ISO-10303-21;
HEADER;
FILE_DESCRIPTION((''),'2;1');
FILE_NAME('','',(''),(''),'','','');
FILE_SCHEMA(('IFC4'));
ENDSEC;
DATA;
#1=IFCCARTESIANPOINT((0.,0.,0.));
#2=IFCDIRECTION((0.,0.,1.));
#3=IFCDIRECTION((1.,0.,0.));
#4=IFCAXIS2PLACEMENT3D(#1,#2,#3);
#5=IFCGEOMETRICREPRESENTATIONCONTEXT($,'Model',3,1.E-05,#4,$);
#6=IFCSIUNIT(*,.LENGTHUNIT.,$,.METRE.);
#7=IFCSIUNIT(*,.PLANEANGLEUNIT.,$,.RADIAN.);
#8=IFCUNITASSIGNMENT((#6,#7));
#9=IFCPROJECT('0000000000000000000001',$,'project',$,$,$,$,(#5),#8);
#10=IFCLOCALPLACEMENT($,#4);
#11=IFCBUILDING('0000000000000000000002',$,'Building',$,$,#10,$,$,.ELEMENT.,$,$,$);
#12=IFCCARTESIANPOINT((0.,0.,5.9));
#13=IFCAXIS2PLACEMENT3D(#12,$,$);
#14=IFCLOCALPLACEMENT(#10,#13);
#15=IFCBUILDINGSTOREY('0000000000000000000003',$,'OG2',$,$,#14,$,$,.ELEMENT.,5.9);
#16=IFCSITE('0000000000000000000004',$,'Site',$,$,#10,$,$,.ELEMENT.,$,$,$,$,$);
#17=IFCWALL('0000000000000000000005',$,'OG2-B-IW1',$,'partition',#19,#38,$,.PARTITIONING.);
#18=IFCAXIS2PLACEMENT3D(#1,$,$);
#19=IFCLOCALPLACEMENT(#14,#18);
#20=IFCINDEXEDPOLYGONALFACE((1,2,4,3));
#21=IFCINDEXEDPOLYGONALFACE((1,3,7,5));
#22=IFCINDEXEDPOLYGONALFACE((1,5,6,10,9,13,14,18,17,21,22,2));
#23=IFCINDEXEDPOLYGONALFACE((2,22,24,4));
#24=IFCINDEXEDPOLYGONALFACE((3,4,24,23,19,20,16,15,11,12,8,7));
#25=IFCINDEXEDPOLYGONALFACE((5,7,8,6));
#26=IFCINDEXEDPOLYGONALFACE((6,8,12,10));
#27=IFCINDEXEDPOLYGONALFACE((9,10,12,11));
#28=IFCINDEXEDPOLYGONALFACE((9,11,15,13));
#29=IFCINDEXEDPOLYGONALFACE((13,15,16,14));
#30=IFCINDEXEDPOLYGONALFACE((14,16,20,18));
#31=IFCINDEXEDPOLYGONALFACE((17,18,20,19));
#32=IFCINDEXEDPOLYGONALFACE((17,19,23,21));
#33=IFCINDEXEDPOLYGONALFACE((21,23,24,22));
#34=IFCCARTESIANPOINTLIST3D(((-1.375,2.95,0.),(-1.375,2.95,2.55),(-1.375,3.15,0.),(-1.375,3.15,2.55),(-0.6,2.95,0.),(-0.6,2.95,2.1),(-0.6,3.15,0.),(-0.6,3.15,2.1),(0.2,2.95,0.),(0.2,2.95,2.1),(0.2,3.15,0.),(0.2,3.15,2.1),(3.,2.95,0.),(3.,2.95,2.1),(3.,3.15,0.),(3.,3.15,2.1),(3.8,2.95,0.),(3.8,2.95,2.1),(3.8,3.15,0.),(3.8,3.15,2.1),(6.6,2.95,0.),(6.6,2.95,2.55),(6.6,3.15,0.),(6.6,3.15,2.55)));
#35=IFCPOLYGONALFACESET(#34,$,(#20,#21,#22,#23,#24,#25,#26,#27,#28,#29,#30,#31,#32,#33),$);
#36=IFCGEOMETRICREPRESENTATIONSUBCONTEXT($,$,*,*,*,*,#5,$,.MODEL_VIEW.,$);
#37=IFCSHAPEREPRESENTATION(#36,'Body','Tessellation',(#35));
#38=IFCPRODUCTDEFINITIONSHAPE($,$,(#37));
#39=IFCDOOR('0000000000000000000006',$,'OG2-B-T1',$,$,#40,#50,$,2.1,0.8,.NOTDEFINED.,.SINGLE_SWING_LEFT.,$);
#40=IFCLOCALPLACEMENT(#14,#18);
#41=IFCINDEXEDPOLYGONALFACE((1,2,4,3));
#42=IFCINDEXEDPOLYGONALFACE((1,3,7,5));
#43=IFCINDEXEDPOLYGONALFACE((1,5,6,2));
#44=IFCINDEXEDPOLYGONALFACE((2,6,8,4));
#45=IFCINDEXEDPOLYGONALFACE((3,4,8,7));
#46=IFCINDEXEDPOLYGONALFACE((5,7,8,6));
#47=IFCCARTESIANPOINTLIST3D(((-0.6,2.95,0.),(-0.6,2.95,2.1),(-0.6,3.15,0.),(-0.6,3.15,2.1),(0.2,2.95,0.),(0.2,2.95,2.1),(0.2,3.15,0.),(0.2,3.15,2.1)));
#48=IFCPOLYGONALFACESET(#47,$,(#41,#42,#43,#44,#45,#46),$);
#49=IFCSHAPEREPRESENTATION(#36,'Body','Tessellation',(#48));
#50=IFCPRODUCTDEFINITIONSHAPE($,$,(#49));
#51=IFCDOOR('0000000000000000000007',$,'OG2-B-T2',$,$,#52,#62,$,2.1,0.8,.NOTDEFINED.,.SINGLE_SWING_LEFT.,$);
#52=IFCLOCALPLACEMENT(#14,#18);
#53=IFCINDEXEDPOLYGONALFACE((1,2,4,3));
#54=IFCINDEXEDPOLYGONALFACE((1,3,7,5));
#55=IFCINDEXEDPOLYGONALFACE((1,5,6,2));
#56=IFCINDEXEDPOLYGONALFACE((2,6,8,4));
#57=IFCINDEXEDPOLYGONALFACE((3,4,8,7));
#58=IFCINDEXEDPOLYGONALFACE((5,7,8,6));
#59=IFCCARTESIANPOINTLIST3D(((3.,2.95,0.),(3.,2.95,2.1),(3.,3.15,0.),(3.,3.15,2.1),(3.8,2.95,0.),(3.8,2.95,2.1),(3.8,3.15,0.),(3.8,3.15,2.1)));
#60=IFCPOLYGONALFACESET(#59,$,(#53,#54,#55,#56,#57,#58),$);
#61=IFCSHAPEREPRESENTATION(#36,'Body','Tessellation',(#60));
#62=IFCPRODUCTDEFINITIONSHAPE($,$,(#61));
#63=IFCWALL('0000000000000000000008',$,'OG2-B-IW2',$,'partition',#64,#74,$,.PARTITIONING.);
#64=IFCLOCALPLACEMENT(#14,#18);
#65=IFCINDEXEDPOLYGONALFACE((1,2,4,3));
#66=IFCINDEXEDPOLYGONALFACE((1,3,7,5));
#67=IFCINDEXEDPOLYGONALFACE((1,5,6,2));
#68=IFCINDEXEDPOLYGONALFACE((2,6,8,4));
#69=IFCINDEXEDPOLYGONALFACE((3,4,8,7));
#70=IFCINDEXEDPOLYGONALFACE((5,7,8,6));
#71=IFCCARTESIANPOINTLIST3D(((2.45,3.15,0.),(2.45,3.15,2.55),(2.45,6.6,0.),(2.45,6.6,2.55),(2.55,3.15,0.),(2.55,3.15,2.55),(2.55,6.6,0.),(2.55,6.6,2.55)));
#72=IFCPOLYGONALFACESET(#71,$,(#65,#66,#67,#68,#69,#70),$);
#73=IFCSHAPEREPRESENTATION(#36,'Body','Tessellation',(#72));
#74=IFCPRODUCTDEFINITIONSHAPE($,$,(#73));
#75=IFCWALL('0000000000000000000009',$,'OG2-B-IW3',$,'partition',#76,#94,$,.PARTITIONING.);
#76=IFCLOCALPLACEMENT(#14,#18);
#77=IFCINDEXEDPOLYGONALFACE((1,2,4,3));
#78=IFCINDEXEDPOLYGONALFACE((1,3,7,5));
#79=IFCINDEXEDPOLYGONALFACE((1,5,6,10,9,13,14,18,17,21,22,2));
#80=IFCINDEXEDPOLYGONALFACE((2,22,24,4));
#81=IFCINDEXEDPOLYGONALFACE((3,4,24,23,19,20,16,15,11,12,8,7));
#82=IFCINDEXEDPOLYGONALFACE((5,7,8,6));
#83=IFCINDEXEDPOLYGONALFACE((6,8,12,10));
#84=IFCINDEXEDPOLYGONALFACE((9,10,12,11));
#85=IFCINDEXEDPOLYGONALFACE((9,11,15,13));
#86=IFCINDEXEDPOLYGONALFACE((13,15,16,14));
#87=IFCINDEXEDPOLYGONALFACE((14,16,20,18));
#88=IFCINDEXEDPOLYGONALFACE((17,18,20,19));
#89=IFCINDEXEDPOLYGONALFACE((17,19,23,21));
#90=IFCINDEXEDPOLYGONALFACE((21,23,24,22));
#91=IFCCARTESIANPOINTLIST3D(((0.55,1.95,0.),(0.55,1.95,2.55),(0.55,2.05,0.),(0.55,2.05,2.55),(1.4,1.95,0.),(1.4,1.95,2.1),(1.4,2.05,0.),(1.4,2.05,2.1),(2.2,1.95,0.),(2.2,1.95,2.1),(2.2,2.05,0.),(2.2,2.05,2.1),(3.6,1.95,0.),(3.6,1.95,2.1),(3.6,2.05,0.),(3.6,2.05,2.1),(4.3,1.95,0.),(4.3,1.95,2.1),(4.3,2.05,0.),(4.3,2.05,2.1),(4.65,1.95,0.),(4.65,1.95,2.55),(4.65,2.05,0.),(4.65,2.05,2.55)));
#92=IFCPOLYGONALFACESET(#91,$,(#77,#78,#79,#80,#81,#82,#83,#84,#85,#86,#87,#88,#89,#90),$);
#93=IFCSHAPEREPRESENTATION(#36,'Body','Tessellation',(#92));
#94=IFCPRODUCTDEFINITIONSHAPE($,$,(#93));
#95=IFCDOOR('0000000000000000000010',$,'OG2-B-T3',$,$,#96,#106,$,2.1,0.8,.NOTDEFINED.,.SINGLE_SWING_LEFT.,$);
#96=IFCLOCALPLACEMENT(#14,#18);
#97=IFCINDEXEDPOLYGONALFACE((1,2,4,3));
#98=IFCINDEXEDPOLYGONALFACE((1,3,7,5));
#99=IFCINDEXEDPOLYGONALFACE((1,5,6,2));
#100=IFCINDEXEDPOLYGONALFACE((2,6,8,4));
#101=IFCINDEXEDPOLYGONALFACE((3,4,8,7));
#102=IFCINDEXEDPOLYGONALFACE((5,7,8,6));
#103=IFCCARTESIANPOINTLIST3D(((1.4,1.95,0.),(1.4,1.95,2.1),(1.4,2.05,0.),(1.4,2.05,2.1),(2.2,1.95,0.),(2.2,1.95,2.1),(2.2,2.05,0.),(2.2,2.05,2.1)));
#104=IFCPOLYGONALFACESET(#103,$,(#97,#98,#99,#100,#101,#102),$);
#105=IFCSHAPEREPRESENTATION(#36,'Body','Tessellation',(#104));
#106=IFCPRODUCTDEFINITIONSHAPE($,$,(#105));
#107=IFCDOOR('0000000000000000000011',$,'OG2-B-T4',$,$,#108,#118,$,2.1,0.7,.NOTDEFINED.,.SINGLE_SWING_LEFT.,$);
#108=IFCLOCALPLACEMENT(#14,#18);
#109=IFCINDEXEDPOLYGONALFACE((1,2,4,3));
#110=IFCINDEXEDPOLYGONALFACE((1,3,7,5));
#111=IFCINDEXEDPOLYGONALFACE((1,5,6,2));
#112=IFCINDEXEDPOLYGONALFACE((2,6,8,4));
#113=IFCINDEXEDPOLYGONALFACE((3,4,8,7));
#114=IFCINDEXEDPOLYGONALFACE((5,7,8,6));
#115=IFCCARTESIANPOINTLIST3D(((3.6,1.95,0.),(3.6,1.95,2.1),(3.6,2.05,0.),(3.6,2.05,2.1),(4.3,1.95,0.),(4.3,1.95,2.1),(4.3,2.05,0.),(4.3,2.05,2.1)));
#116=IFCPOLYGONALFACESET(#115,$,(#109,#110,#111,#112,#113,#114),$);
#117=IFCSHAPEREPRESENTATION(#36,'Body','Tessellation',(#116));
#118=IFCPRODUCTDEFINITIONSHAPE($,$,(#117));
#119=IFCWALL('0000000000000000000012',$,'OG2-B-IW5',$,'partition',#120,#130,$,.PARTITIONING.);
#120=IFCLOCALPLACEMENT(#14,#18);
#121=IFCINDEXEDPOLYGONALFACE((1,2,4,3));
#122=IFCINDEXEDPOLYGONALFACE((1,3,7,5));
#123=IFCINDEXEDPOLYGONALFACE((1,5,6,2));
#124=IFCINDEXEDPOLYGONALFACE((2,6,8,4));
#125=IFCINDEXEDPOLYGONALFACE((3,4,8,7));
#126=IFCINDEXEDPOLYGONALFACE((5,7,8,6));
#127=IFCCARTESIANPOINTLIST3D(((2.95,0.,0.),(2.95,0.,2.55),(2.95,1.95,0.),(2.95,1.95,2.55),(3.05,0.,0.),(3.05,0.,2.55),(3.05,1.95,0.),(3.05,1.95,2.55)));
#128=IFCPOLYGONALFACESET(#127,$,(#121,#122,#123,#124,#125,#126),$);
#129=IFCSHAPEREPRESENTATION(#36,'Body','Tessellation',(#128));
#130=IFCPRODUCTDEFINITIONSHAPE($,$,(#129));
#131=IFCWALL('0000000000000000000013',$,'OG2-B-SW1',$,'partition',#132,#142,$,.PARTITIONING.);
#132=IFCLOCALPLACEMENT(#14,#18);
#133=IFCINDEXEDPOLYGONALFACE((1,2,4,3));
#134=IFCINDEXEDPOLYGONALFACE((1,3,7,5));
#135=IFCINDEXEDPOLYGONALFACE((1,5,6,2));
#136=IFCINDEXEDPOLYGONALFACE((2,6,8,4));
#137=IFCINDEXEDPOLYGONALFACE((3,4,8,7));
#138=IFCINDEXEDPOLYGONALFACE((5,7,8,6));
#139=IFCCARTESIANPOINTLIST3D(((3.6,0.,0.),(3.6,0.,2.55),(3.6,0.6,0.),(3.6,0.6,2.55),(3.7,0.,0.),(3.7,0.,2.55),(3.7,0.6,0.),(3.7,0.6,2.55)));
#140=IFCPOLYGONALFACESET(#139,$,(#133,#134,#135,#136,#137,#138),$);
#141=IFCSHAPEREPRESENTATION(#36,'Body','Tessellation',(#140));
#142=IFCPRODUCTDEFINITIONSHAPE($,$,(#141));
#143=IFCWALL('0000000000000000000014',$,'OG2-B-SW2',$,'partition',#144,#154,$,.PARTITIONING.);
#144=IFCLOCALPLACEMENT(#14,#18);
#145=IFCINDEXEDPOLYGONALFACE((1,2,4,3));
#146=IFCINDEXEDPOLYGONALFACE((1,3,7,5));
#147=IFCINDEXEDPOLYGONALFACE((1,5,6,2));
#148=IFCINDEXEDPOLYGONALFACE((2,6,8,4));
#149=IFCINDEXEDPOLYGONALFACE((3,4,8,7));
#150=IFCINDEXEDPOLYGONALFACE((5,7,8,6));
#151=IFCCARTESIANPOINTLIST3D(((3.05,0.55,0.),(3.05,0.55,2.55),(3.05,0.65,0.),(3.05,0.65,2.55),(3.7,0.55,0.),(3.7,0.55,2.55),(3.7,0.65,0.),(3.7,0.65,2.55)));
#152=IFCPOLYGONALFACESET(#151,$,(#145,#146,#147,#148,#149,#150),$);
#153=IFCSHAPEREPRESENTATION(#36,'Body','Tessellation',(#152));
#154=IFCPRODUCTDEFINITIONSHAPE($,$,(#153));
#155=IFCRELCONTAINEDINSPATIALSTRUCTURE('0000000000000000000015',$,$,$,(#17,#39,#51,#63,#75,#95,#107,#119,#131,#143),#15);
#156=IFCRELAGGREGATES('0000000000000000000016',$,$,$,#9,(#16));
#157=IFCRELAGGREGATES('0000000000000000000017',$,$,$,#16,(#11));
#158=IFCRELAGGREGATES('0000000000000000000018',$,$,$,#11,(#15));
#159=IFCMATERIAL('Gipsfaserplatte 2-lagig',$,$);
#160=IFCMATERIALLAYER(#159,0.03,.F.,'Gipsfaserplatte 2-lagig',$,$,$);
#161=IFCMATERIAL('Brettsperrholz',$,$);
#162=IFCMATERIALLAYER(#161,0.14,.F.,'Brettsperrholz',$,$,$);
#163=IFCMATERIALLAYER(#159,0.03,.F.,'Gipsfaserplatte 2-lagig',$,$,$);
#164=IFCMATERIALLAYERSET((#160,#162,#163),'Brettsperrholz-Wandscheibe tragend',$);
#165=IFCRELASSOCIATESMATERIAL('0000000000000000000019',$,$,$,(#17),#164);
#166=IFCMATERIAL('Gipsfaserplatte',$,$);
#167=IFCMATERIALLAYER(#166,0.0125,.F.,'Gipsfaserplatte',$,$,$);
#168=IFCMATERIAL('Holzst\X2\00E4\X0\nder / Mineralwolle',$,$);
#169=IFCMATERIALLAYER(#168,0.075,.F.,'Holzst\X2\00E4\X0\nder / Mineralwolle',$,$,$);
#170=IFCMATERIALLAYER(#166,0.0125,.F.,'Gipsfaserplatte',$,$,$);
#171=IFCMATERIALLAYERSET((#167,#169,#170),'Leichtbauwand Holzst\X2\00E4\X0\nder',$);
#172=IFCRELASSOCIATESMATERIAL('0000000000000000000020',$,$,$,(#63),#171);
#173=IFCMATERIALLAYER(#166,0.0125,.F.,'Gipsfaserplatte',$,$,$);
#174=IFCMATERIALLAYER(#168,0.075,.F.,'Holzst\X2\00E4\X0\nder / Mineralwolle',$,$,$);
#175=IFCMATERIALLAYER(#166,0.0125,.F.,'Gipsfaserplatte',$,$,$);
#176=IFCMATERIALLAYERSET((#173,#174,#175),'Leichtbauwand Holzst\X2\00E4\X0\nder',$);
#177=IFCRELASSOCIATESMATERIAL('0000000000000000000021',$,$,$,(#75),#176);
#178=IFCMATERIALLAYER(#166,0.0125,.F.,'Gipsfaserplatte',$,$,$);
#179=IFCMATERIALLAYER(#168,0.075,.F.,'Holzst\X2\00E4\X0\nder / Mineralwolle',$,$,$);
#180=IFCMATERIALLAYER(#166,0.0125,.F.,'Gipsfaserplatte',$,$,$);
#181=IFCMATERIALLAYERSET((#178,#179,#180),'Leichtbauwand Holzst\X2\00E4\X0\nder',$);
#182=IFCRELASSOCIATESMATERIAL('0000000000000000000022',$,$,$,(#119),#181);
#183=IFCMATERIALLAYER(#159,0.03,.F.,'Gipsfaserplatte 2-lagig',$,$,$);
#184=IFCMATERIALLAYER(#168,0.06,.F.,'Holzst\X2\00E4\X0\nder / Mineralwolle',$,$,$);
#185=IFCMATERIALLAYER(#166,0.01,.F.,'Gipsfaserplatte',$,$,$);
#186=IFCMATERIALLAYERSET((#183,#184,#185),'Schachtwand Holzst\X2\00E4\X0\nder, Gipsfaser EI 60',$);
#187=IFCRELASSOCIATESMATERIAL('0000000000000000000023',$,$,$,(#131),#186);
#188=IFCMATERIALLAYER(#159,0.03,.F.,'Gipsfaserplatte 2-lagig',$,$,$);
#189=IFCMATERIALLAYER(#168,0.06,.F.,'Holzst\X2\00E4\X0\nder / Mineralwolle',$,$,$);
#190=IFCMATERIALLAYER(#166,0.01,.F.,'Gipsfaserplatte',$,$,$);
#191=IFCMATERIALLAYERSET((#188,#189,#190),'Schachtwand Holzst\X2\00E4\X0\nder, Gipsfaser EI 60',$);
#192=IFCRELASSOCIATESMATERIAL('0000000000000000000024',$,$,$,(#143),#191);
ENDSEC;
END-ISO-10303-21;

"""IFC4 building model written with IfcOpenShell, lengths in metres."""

from ifc_helpers import new_model, si_unit, frame, frame_2d, origin, origin_with_axes, place, context, subcontext, project, spatial, rectangle, extrude, material, layer, layer_set, element, fill, save


model = new_model("IFC4")

# Units and contexts
model_context = context("Model", 3, precision=1e-05, world=origin_with_axes())
sub_context = subcontext(model_context, None, None, "MODEL_VIEW")
ifc_project = project(units=[si_unit("LENGTHUNIT", "METRE"), si_unit("PLANEANGLEUNIT", "RADIAN")], contexts=[model_context])

# Site, building, storey
placement = place(None, origin_with_axes())
site = spatial("IfcSite", under=ifc_project, at=placement, Name="Site", CompositionType="ELEMENT")
building = spatial("IfcBuilding", under=site, at=placement, Name="Building", CompositionType="ELEMENT")
storey_placement = place(placement, frame((0.0, 0.0, 5.9)))
storey = spatial("IfcBuildingStorey", under=building, at=storey_placement, Name="OG2", CompositionType="ELEMENT", Elevation=5.9)

# Shared definitions
ifc_material_1 = material(Name="Gipsfaserplatte")

# Wall, openings, doors
ifc_material_2 = material(Name="Gipsfaserplatte 2-lagig")
ifc_layer_1 = layer(ifc_material_2, 0.03, ventilated=False, Name="Gipsfaserplatte 2-lagig")
ifc_material_3 = material(Name="Brettsperrholz")
ifc_layer_2 = layer(ifc_material_3, 0.14, ventilated=False, Name="Brettsperrholz")
ifc_layer_3 = layer(ifc_material_2, 0.03, ventilated=False, Name="Gipsfaserplatte 2-lagig")
ifc_layer_set_1 = layer_set([ifc_layer_1, ifc_layer_2, ifc_layer_3], Name="Brettsperrholz-Wandscheibe tragend")
wall_1_placement = place(storey_placement, frame((-1.375, 3.05, 0.0), z_axis=(0.0, 0.0, 1.0), x_axis=(1.0, 0.0, 0.0)))
wall_1 = element("IfcWall", 1, at=wall_1_placement, inside=storey, material=ifc_layer_set_1, Name="OG2-B-IW1", ObjectType="partition", PredefinedType="PARTITIONING", context=sub_context, shape_type="SweptSolid", body=[
    extrude(rectangle(XDim=7.975, YDim=0.2, at=frame_2d((3.9875, 0.0))), origin(), (0.0, 0.0, 1.0), 2.55),
])
opening_1_placement = place(wall_1_placement, frame((1.175, 0.15, 0.0), z_axis=(0.0, -1.0, 0.0), x_axis=(1.0, 0.0, 0.0)))
opening_1 = element("IfcOpeningElement", 2, at=opening_1_placement, cuts=wall_1, PredefinedType="OPENING", context=sub_context, shape_type="SweptSolid", body=[
    extrude(rectangle(XDim=0.8, YDim=2.1, at=frame_2d((0.0, 1.05))), origin(), (0.0, 0.0, 1.0), 0.3),
])
opening_2_placement = place(wall_1_placement, frame((4.775, 0.15, 0.0), z_axis=(0.0, -1.0, 0.0), x_axis=(1.0, 0.0, 0.0)))
opening_2 = element("IfcOpeningElement", 3, at=opening_2_placement, cuts=wall_1, PredefinedType="OPENING", context=sub_context, shape_type="SweptSolid", body=[
    extrude(rectangle(XDim=0.8, YDim=2.1, at=frame_2d((0.0, 1.05))), origin(), (0.0, 0.0, 1.0), 0.3),
])
door_1_placement = place(wall_1_placement, frame((1.175, 0.1, 0.0), z_axis=(0.0, -1.0, 0.0), x_axis=(1.0, 0.0, 0.0)))
door_1 = element("IfcDoor", 4, at=door_1_placement, inside=storey, Name="OG2-B-T1", OperationType="SINGLE_SWING_LEFT", OverallHeight=2.1, OverallWidth=0.8, PredefinedType="NOTDEFINED", context=sub_context, shape_type="SweptSolid", body=[
    extrude(rectangle(XDim=0.8, YDim=2.1, at=frame_2d((0.0, 1.05))), origin(), (0.0, 0.0, 1.0), 0.2),
])
fill(opening_1, door_1)
door_2_placement = place(wall_1_placement, frame((4.775, 0.1, 0.0), z_axis=(0.0, -1.0, 0.0), x_axis=(1.0, 0.0, 0.0)))
door_2 = element("IfcDoor", 5, at=door_2_placement, inside=storey, Name="OG2-B-T2", OperationType="SINGLE_SWING_LEFT", OverallHeight=2.1, OverallWidth=0.8, PredefinedType="NOTDEFINED", context=sub_context, shape_type="SweptSolid", body=[
    extrude(rectangle(XDim=0.8, YDim=2.1, at=frame_2d((0.0, 1.05))), origin(), (0.0, 0.0, 1.0), 0.2),
])
fill(opening_2, door_2)

# Wall
ifc_layer_4 = layer(ifc_material_1, 0.0125, ventilated=False, Name="Gipsfaserplatte")
ifc_material_4 = material(Name="Holzständer / Mineralwolle")
ifc_layer_5 = layer(ifc_material_4, 0.075, ventilated=False, Name="Holzständer / Mineralwolle")
ifc_layer_6 = layer(ifc_material_1, 0.0125, ventilated=False, Name="Gipsfaserplatte")
ifc_layer_set_2 = layer_set([ifc_layer_4, ifc_layer_5, ifc_layer_6], Name="Leichtbauwand Holzständer")
wall_2_placement = place(storey_placement, frame((2.5, 3.15, 0.0), z_axis=(0.0, 0.0, 1.0), x_axis=(0.0, 1.0, 0.0)))
element("IfcWall", 6, at=wall_2_placement, inside=storey, material=ifc_layer_set_2, Name="OG2-B-IW2", ObjectType="partition", PredefinedType="PARTITIONING", context=sub_context, shape_type="SweptSolid", body=[
    extrude(rectangle(XDim=3.45, YDim=0.1, at=frame_2d((1.725, 0.0))), origin(), (0.0, 0.0, 1.0), 2.55),
])

# Wall, openings, doors
ifc_layer_7 = layer(ifc_material_1, 0.0125, ventilated=False, Name="Gipsfaserplatte")
ifc_layer_8 = layer(ifc_material_4, 0.075, ventilated=False, Name="Holzständer / Mineralwolle")
ifc_layer_9 = layer(ifc_material_1, 0.0125, ventilated=False, Name="Gipsfaserplatte")
ifc_layer_set_3 = layer_set([ifc_layer_7, ifc_layer_8, ifc_layer_9], Name="Leichtbauwand Holzständer")
wall_3_placement = place(storey_placement, frame((0.55, 2.0, 0.0), z_axis=(0.0, 0.0, 1.0), x_axis=(1.0, 0.0, 0.0)))
wall_3 = element("IfcWall", 7, at=wall_3_placement, inside=storey, material=ifc_layer_set_3, Name="OG2-B-IW3", ObjectType="partition", PredefinedType="PARTITIONING", context=sub_context, shape_type="SweptSolid", body=[
    extrude(rectangle(XDim=4.1, YDim=0.1, at=frame_2d((2.05, 0.0))), origin(), (0.0, 0.0, 1.0), 2.55),
])
opening_3_placement = place(wall_3_placement, frame((1.25, 0.1, 0.0), z_axis=(0.0, -1.0, 0.0), x_axis=(1.0, 0.0, 0.0)))
opening_3 = element("IfcOpeningElement", 8, at=opening_3_placement, cuts=wall_3, PredefinedType="OPENING", context=sub_context, shape_type="SweptSolid", body=[
    extrude(rectangle(XDim=0.8, YDim=2.1, at=frame_2d((0.0, 1.05))), origin(), (0.0, 0.0, 1.0), 0.2),
])
opening_4_placement = place(wall_3_placement, frame((3.4, 0.1, 0.0), z_axis=(0.0, -1.0, 0.0), x_axis=(1.0, 0.0, 0.0)))
opening_4 = element("IfcOpeningElement", 9, at=opening_4_placement, cuts=wall_3, PredefinedType="OPENING", context=sub_context, shape_type="SweptSolid", body=[
    extrude(rectangle(XDim=0.7, YDim=2.1, at=frame_2d((0.0, 1.05))), origin(), (0.0, 0.0, 1.0), 0.2),
])
door_3_placement = place(wall_3_placement, frame((1.25, 0.05, 0.0), z_axis=(0.0, -1.0, 0.0), x_axis=(1.0, 0.0, 0.0)))
door_3 = element("IfcDoor", 10, at=door_3_placement, inside=storey, Name="OG2-B-T3", OperationType="SINGLE_SWING_LEFT", OverallHeight=2.1, OverallWidth=0.8, PredefinedType="NOTDEFINED", context=sub_context, shape_type="SweptSolid", body=[
    extrude(rectangle(XDim=0.8, YDim=2.1, at=frame_2d((0.0, 1.05))), origin(), (0.0, 0.0, 1.0), 0.1),
])
fill(opening_3, door_3)
door_4_placement = place(wall_3_placement, frame((3.4, 0.05, 0.0), z_axis=(0.0, -1.0, 0.0), x_axis=(1.0, 0.0, 0.0)))
door_4 = element("IfcDoor", 11, at=door_4_placement, inside=storey, Name="OG2-B-T4", OperationType="SINGLE_SWING_LEFT", OverallHeight=2.1, OverallWidth=0.7, PredefinedType="NOTDEFINED", context=sub_context, shape_type="SweptSolid", body=[
    extrude(rectangle(XDim=0.7, YDim=2.1, at=frame_2d((0.0, 1.05))), origin(), (0.0, 0.0, 1.0), 0.1),
])
fill(opening_4, door_4)

# Walls
ifc_layer_10 = layer(ifc_material_1, 0.0125, ventilated=False, Name="Gipsfaserplatte")
ifc_layer_11 = layer(ifc_material_4, 0.075, ventilated=False, Name="Holzständer / Mineralwolle")
ifc_layer_12 = layer(ifc_material_1, 0.0125, ventilated=False, Name="Gipsfaserplatte")
ifc_layer_set_4 = layer_set([ifc_layer_10, ifc_layer_11, ifc_layer_12], Name="Leichtbauwand Holzständer")
wall_4_placement = place(storey_placement, frame((3.0, 0.0, 0.0), z_axis=(0.0, 0.0, 1.0), x_axis=(0.0, 1.0, 0.0)))
element("IfcWall", 12, at=wall_4_placement, inside=storey, material=ifc_layer_set_4, Name="OG2-B-IW5", ObjectType="partition", PredefinedType="PARTITIONING", context=sub_context, shape_type="SweptSolid", body=[
    extrude(rectangle(XDim=1.95, YDim=0.1, at=frame_2d((0.975, 0.0))), origin(), (0.0, 0.0, 1.0), 2.55),
])
ifc_layer_13 = layer(ifc_material_2, 0.03, ventilated=False, Name="Gipsfaserplatte 2-lagig")
ifc_layer_14 = layer(ifc_material_4, 0.06, ventilated=False, Name="Holzständer / Mineralwolle")
ifc_layer_15 = layer(ifc_material_1, 0.01, ventilated=False, Name="Gipsfaserplatte")
ifc_layer_set_5 = layer_set([ifc_layer_13, ifc_layer_14, ifc_layer_15], Name="Schachtwand Holzständer, Gipsfaser EI 60")
wall_5_placement = place(storey_placement, frame((3.65, 0.0, 0.0), z_axis=(0.0, 0.0, 1.0), x_axis=(0.0, 1.0, 0.0)))
element("IfcWall", 13, at=wall_5_placement, inside=storey, material=ifc_layer_set_5, Name="OG2-B-SW1", ObjectType="partition", PredefinedType="PARTITIONING", context=sub_context, shape_type="SweptSolid", body=[
    extrude(rectangle(XDim=0.6, YDim=0.1, at=frame_2d((0.3, 0.0))), origin(), (0.0, 0.0, 1.0), 2.55),
])
ifc_layer_16 = layer(ifc_material_2, 0.03, ventilated=False, Name="Gipsfaserplatte 2-lagig")
ifc_layer_17 = layer(ifc_material_4, 0.06, ventilated=False, Name="Holzständer / Mineralwolle")
ifc_layer_18 = layer(ifc_material_1, 0.01, ventilated=False, Name="Gipsfaserplatte")
ifc_layer_set_6 = layer_set([ifc_layer_16, ifc_layer_17, ifc_layer_18], Name="Schachtwand Holzständer, Gipsfaser EI 60")
wall_6_placement = place(storey_placement, frame((3.05, 0.6, 0.0), z_axis=(0.0, 0.0, 1.0), x_axis=(1.0, 0.0, 0.0)))
element("IfcWall", 14, at=wall_6_placement, inside=storey, material=ifc_layer_set_6, Name="OG2-B-SW2", ObjectType="partition", PredefinedType="PARTITIONING", context=sub_context, shape_type="SweptSolid", body=[
    extrude(rectangle(XDim=0.65, YDim=0.1, at=frame_2d((0.325, 0.0))), origin(), (0.0, 0.0, 1.0), 2.55),
])

save(model, "model.ifc")
